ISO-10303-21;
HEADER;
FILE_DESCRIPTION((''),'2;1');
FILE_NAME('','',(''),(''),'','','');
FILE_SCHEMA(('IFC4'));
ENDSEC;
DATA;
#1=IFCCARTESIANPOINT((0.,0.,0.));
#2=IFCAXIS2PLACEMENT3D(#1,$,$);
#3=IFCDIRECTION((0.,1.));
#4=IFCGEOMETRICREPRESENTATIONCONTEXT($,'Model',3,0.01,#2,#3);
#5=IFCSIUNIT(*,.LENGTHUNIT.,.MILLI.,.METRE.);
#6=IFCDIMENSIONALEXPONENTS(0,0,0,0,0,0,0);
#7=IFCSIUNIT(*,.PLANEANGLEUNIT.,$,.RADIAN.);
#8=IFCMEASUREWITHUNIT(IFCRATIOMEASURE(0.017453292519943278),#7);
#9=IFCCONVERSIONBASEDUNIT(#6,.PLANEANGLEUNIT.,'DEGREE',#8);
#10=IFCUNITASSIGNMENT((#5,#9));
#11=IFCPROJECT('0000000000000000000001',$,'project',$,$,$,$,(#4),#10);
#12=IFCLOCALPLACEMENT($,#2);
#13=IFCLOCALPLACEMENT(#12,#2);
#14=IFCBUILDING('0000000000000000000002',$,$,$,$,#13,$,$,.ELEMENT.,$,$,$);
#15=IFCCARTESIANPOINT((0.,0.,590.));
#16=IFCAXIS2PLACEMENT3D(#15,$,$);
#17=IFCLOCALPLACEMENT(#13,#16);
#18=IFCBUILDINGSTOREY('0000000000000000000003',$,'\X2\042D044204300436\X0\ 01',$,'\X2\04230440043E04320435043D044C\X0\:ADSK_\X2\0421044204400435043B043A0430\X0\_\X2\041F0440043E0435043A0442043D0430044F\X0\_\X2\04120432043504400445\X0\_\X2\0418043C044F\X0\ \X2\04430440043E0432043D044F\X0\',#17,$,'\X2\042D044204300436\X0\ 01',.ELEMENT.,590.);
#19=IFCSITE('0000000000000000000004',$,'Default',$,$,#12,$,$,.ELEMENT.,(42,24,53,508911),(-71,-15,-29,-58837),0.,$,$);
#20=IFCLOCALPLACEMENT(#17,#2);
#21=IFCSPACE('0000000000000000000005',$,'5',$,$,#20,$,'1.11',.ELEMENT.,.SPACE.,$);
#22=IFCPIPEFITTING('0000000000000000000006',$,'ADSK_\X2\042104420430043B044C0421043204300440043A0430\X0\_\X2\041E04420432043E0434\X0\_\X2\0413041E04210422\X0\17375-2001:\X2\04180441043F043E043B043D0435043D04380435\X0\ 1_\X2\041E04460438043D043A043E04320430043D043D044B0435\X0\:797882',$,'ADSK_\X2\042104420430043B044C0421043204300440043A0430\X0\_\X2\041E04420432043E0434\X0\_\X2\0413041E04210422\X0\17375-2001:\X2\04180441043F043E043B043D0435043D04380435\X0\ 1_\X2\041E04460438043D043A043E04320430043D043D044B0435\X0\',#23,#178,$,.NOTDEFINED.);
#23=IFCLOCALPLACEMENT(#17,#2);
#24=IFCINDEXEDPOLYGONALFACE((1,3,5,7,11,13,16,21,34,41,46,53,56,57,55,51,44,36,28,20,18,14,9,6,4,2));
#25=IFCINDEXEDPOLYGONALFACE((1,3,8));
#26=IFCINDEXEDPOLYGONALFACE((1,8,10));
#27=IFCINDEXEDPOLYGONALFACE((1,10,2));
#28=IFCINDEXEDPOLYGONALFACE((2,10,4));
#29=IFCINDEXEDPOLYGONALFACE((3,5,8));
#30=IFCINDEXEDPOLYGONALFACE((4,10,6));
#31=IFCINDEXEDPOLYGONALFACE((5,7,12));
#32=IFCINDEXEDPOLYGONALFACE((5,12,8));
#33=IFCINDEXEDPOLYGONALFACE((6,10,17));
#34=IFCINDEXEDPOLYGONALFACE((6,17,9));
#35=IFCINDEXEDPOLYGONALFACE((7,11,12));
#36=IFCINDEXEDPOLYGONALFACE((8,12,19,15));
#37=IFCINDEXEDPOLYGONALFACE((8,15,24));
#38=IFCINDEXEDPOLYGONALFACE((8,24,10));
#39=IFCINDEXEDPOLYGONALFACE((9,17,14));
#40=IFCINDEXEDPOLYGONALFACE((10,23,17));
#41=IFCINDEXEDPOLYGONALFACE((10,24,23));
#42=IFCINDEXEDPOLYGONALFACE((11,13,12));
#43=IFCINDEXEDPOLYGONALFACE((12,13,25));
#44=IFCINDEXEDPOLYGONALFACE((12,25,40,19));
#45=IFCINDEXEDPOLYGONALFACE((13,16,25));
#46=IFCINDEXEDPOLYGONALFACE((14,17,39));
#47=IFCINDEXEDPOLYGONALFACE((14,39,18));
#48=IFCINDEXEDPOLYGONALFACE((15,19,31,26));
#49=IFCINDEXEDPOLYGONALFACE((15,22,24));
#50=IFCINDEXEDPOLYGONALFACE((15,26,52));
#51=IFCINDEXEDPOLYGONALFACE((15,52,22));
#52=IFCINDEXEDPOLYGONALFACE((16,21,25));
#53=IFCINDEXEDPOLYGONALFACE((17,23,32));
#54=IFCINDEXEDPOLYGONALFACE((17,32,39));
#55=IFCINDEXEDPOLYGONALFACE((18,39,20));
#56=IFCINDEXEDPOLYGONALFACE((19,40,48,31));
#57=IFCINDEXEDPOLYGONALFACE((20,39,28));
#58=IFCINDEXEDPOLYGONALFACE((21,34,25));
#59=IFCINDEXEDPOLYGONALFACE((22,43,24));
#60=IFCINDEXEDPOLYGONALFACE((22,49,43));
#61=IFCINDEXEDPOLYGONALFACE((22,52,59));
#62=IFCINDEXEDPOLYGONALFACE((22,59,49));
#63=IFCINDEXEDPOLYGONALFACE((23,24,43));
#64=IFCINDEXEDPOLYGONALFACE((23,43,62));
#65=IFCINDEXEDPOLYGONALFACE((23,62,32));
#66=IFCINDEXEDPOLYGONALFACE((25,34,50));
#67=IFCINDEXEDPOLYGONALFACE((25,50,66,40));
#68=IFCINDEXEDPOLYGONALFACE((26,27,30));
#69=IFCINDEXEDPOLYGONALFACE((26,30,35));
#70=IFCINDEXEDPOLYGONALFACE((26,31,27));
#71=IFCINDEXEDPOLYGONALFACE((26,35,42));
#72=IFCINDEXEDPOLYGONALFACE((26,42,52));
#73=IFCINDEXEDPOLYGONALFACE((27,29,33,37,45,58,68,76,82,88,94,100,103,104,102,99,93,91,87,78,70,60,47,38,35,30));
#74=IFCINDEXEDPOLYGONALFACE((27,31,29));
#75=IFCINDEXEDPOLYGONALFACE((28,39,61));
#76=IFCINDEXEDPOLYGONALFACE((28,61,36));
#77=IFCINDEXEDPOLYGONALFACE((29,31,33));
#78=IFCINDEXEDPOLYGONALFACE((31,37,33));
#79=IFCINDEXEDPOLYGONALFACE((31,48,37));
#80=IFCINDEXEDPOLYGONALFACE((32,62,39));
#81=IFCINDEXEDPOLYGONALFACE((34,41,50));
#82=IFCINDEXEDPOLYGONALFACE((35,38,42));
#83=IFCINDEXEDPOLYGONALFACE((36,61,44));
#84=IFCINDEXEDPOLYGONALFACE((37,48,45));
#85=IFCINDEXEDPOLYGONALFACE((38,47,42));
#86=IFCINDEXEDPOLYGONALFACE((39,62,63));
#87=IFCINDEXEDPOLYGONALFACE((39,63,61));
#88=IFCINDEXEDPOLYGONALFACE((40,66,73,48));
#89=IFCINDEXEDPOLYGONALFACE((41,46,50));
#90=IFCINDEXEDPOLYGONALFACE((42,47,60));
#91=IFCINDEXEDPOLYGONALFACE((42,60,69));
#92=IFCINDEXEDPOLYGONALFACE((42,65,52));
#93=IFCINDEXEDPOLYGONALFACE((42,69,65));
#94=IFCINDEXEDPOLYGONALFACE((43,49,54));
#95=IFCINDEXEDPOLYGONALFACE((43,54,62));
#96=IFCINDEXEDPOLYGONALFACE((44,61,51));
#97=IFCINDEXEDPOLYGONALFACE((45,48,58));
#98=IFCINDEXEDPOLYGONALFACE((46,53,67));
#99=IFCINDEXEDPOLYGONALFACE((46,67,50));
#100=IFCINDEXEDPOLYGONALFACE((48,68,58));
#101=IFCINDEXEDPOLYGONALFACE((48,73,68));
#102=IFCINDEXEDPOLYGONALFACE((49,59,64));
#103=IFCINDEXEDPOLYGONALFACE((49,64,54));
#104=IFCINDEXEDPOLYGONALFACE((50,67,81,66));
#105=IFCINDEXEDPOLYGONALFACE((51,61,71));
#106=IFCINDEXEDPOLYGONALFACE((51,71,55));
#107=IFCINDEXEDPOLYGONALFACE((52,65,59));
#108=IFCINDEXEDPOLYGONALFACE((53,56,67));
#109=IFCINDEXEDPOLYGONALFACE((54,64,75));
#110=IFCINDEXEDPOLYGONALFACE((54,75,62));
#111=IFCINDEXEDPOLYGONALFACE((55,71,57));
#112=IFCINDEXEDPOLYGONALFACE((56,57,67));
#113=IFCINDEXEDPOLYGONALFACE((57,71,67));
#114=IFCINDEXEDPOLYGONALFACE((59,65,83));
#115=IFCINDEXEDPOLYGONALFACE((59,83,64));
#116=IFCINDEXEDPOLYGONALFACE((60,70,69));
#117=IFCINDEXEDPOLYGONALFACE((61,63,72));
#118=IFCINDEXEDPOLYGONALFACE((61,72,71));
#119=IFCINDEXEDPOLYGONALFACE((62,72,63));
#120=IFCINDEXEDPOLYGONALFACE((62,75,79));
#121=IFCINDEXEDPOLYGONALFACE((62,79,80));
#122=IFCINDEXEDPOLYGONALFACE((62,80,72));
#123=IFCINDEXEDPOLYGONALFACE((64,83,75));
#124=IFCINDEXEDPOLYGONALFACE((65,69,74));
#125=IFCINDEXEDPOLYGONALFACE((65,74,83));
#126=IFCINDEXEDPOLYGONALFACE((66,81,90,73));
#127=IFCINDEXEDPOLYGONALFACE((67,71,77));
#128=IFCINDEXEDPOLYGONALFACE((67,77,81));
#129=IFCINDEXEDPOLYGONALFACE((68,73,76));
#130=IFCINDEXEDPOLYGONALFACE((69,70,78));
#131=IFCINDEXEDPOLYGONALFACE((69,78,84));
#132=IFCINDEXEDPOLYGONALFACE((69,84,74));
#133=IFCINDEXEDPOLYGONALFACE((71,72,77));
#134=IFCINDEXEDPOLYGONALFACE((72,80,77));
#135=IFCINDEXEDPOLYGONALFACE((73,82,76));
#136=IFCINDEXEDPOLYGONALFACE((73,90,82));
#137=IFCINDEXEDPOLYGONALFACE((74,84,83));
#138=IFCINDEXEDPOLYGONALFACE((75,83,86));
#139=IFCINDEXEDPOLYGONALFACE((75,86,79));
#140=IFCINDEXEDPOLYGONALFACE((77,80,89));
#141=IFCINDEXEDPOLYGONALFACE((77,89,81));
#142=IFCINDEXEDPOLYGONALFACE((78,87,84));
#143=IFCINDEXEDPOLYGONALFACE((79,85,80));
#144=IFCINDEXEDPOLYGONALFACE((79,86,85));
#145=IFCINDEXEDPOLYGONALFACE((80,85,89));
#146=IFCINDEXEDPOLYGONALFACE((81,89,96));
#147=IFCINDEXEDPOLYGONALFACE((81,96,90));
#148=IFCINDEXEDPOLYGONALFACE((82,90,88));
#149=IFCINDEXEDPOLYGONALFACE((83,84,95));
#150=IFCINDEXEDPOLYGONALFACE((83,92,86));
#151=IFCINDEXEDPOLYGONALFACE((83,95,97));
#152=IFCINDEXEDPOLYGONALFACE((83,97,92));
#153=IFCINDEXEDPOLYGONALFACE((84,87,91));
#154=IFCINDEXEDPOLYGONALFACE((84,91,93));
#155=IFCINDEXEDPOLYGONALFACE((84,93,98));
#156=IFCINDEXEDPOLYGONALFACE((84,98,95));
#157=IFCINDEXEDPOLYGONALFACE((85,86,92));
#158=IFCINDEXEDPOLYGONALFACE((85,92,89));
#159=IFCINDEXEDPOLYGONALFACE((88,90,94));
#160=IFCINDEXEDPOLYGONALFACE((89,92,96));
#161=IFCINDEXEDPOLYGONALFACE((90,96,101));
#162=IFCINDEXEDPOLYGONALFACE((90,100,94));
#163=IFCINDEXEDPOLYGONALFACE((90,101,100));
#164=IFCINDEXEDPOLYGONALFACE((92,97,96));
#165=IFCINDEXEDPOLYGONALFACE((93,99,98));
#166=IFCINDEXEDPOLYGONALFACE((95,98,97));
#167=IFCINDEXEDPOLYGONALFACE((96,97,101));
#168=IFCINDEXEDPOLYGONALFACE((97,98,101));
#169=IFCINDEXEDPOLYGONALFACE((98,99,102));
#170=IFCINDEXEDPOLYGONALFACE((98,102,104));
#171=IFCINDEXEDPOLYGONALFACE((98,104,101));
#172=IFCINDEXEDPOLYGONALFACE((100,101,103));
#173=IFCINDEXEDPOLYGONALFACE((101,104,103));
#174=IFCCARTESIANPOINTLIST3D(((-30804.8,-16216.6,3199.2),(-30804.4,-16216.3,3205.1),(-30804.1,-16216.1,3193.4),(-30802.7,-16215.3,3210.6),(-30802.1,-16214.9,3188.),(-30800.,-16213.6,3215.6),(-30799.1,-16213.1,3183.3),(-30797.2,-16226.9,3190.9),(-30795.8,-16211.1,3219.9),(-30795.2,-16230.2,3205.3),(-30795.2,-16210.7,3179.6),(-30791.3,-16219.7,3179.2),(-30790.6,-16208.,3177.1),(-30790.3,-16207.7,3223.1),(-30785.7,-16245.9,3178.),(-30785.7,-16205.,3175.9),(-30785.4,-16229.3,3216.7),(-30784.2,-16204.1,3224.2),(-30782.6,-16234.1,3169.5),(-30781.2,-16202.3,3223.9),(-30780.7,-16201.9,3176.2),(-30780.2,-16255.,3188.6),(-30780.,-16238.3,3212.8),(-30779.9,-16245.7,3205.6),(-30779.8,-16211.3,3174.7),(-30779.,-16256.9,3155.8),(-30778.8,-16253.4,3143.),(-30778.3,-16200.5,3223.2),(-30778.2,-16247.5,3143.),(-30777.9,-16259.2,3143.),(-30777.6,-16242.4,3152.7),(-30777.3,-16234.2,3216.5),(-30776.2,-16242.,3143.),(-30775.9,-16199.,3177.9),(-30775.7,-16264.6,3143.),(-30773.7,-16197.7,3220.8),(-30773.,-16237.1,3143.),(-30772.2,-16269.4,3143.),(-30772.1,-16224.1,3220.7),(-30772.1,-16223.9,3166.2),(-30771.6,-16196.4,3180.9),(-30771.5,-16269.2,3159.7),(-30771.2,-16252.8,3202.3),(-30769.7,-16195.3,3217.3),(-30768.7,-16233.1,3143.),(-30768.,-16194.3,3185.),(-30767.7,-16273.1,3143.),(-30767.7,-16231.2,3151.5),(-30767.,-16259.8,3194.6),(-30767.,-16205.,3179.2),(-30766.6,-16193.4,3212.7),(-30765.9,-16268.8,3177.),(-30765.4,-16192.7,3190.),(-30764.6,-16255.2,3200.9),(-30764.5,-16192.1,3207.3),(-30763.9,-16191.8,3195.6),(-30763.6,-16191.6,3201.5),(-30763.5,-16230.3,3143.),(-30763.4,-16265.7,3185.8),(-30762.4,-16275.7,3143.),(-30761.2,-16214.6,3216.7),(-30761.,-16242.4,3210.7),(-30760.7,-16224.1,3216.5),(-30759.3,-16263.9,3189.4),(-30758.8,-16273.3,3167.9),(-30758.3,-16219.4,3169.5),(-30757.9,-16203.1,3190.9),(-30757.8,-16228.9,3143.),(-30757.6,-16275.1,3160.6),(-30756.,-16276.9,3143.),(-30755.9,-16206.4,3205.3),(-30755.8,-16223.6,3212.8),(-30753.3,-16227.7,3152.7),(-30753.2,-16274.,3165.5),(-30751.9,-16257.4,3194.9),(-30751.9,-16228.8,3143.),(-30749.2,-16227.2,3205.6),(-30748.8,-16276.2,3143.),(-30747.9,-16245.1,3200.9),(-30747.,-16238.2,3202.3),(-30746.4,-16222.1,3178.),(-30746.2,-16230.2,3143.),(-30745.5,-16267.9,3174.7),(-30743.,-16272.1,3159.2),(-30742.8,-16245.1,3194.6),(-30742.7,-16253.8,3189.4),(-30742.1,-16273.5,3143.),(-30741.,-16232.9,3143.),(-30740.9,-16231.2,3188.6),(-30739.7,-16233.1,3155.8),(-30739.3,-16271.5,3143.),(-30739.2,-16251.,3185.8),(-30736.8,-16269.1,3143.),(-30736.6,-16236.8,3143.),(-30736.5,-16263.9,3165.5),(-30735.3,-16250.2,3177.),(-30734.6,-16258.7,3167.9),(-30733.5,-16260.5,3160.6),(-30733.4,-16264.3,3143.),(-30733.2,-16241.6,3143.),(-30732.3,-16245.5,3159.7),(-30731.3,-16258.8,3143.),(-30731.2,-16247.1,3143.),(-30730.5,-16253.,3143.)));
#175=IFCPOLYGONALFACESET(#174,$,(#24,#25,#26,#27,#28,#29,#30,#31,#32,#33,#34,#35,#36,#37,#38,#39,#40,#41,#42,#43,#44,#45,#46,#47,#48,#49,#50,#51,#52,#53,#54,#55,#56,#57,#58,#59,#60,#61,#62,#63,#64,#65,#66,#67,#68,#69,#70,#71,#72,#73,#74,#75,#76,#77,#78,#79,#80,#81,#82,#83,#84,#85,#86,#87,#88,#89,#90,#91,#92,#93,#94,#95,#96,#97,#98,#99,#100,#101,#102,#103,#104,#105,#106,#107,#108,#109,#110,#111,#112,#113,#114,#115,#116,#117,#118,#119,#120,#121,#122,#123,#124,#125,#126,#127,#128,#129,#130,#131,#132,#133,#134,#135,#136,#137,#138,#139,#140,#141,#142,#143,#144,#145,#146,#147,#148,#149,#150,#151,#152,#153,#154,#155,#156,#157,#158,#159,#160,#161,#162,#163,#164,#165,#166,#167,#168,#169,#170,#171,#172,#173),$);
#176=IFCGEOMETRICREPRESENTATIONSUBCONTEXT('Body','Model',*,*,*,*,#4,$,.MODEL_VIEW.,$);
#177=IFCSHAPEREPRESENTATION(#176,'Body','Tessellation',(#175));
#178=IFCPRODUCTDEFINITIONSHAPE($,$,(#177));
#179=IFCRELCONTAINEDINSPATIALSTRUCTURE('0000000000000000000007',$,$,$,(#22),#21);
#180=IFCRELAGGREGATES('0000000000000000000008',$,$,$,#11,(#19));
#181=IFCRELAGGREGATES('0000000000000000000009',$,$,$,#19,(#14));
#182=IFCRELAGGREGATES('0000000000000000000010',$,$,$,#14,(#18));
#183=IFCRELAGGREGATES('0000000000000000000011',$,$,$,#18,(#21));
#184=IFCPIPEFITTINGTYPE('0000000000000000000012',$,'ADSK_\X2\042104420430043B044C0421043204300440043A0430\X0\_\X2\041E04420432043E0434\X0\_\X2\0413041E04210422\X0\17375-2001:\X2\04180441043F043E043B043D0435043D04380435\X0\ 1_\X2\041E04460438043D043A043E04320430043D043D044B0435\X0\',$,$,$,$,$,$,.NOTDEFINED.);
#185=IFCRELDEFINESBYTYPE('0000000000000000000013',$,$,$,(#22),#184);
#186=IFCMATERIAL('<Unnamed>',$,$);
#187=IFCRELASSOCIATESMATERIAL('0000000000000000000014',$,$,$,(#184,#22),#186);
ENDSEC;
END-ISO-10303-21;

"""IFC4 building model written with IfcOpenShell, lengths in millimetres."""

from ifc_helpers import new_model, entity, si_unit, converted_unit, direction, frame, origin, place, context, subcontext, project, spatial, source, transform, mapped, material, type_object, type_shapes, element, save


model = new_model("IFC4")

# Units and contexts
model_context = context("Model", 3, precision=0.01, world=origin(), true_north=direction((0.0, 1.0)))
body_context = subcontext(model_context, "Body", "Model", "MODEL_VIEW")
ifc_project = project(units=[si_unit("LENGTHUNIT", "METRE", prefix="MILLI"), converted_unit("PLANEANGLEUNIT", "DEGREE", entity("IfcRatioMeasure", 0.017453292519943278), si_unit("PLANEANGLEUNIT", "RADIAN"), dimensions=[0, 0, 0, 0, 0, 0, 0])], contexts=[model_context])

# Site, building, storey
site_placement = place(None, origin())
site = spatial("IfcSite", under=ifc_project, at=site_placement, Name="Default", CompositionType="ELEMENT", RefLatitude=(42, 24, 53, 508911), RefLongitude=(-71, -15, -29, -58837), RefElevation=0.0)
building_placement = place(site_placement, origin())
building = spatial("IfcBuilding", under=site, at=building_placement, CompositionType="ELEMENT")
storey_placement = place(building_placement, frame((0.0, 0.0, 590.0)))
storey = spatial("IfcBuildingStorey", under=building, at=storey_placement, Name="Этаж 01", ObjectType="Уровень:ADSK_Стрелка_Проектная_Вверх_Имя уровня", LongName="Этаж 01", CompositionType="ELEMENT", Elevation=590.0)

# Shared definitions
ifc_material_1 = material(Name="<Unnamed>")

# Shared definitions
space_1_placement = place(storey_placement, origin())
space_1 = spatial("IfcSpace", under=storey, at=space_1_placement, Name="5", LongName="1.11", CompositionType="ELEMENT", PredefinedType="SPACE")

# Pipe fitting
pipe_fitting_type_1 = type_object("IfcPipeFittingType", Name="ADSK_СтальСварка_Отвод_ГОСТ17375-2001:Исполнение 1_Оцинкованные", PredefinedType="NOTDEFINED", material=ifc_material_1)
ifc_direction_1 = entity("IfcDirection", [0.0, 0.0, 1.0])
trimmed_curve_1 = entity("IfcTrimmedCurve", entity("IfcCircle", entity("IfcAxis2Placement2D", entity("IfcCartesianPoint", [-57.0, 0.0]), entity("IfcDirection", [0.0, 1.0])), 57.0), [entity("IfcParameterValue", 270.0)], [entity("IfcParameterValue", 0.0)], True, "PARAMETER")
shared_shape_1 = source(origin(), body_context, "Body", "AdvancedSweptSolid", [
    entity("IfcSurfaceCurveSweptAreaSolid", entity("IfcCircleProfileDef", "AREA", None, entity("IfcAxis2Placement2D", entity("IfcCartesianPoint", [0.0, 0.0]), entity("IfcDirection", [1.0, 0.0])), 24.1), entity("IfcAxis2Placement3D", entity("IfcCartesianPoint", [-57.0, 0.0, 0.0]), ifc_direction_1, entity("IfcDirection", [0.0, -1.0, 0.0])), trimmed_curve_1, 0.0, 90.0, entity("IfcSurfaceOfLinearExtrusion", entity("IfcArbitraryOpenProfileDef", "CURVE", None, trimmed_curve_1), entity("IfcAxis2Placement3D", entity("IfcCartesianPoint", [0.0, 0.0, -304.8])), ifc_direction_1, 1.0)),
])
type_shapes(pipe_fitting_type_1, [shared_shape_1])
pipe_fitting_1_placement = place(space_1_placement, frame((-30754.6, -16252.8, 3200.0), z_axis=(0.855267, 0.518188, 0.0), x_axis=(0.518188, -0.855267, 0.0)))
element("IfcPipeFitting", 1, at=pipe_fitting_1_placement, inside=space_1, type_object=pipe_fitting_type_1, material=ifc_material_1, Name="ADSK_СтальСварка_Отвод_ГОСТ17375-2001:Исполнение 1_Оцинкованные:797882", ObjectType="ADSK_СтальСварка_Отвод_ГОСТ17375-2001:Исполнение 1_Оцинкованные", PredefinedType="NOTDEFINED", context=body_context, shape_type="MappedRepresentation", body=[
    mapped(shared_shape_1, transform((0.0, 0.0, 0.0), scale=1.0)),
])

save(model, "model.ifc")
